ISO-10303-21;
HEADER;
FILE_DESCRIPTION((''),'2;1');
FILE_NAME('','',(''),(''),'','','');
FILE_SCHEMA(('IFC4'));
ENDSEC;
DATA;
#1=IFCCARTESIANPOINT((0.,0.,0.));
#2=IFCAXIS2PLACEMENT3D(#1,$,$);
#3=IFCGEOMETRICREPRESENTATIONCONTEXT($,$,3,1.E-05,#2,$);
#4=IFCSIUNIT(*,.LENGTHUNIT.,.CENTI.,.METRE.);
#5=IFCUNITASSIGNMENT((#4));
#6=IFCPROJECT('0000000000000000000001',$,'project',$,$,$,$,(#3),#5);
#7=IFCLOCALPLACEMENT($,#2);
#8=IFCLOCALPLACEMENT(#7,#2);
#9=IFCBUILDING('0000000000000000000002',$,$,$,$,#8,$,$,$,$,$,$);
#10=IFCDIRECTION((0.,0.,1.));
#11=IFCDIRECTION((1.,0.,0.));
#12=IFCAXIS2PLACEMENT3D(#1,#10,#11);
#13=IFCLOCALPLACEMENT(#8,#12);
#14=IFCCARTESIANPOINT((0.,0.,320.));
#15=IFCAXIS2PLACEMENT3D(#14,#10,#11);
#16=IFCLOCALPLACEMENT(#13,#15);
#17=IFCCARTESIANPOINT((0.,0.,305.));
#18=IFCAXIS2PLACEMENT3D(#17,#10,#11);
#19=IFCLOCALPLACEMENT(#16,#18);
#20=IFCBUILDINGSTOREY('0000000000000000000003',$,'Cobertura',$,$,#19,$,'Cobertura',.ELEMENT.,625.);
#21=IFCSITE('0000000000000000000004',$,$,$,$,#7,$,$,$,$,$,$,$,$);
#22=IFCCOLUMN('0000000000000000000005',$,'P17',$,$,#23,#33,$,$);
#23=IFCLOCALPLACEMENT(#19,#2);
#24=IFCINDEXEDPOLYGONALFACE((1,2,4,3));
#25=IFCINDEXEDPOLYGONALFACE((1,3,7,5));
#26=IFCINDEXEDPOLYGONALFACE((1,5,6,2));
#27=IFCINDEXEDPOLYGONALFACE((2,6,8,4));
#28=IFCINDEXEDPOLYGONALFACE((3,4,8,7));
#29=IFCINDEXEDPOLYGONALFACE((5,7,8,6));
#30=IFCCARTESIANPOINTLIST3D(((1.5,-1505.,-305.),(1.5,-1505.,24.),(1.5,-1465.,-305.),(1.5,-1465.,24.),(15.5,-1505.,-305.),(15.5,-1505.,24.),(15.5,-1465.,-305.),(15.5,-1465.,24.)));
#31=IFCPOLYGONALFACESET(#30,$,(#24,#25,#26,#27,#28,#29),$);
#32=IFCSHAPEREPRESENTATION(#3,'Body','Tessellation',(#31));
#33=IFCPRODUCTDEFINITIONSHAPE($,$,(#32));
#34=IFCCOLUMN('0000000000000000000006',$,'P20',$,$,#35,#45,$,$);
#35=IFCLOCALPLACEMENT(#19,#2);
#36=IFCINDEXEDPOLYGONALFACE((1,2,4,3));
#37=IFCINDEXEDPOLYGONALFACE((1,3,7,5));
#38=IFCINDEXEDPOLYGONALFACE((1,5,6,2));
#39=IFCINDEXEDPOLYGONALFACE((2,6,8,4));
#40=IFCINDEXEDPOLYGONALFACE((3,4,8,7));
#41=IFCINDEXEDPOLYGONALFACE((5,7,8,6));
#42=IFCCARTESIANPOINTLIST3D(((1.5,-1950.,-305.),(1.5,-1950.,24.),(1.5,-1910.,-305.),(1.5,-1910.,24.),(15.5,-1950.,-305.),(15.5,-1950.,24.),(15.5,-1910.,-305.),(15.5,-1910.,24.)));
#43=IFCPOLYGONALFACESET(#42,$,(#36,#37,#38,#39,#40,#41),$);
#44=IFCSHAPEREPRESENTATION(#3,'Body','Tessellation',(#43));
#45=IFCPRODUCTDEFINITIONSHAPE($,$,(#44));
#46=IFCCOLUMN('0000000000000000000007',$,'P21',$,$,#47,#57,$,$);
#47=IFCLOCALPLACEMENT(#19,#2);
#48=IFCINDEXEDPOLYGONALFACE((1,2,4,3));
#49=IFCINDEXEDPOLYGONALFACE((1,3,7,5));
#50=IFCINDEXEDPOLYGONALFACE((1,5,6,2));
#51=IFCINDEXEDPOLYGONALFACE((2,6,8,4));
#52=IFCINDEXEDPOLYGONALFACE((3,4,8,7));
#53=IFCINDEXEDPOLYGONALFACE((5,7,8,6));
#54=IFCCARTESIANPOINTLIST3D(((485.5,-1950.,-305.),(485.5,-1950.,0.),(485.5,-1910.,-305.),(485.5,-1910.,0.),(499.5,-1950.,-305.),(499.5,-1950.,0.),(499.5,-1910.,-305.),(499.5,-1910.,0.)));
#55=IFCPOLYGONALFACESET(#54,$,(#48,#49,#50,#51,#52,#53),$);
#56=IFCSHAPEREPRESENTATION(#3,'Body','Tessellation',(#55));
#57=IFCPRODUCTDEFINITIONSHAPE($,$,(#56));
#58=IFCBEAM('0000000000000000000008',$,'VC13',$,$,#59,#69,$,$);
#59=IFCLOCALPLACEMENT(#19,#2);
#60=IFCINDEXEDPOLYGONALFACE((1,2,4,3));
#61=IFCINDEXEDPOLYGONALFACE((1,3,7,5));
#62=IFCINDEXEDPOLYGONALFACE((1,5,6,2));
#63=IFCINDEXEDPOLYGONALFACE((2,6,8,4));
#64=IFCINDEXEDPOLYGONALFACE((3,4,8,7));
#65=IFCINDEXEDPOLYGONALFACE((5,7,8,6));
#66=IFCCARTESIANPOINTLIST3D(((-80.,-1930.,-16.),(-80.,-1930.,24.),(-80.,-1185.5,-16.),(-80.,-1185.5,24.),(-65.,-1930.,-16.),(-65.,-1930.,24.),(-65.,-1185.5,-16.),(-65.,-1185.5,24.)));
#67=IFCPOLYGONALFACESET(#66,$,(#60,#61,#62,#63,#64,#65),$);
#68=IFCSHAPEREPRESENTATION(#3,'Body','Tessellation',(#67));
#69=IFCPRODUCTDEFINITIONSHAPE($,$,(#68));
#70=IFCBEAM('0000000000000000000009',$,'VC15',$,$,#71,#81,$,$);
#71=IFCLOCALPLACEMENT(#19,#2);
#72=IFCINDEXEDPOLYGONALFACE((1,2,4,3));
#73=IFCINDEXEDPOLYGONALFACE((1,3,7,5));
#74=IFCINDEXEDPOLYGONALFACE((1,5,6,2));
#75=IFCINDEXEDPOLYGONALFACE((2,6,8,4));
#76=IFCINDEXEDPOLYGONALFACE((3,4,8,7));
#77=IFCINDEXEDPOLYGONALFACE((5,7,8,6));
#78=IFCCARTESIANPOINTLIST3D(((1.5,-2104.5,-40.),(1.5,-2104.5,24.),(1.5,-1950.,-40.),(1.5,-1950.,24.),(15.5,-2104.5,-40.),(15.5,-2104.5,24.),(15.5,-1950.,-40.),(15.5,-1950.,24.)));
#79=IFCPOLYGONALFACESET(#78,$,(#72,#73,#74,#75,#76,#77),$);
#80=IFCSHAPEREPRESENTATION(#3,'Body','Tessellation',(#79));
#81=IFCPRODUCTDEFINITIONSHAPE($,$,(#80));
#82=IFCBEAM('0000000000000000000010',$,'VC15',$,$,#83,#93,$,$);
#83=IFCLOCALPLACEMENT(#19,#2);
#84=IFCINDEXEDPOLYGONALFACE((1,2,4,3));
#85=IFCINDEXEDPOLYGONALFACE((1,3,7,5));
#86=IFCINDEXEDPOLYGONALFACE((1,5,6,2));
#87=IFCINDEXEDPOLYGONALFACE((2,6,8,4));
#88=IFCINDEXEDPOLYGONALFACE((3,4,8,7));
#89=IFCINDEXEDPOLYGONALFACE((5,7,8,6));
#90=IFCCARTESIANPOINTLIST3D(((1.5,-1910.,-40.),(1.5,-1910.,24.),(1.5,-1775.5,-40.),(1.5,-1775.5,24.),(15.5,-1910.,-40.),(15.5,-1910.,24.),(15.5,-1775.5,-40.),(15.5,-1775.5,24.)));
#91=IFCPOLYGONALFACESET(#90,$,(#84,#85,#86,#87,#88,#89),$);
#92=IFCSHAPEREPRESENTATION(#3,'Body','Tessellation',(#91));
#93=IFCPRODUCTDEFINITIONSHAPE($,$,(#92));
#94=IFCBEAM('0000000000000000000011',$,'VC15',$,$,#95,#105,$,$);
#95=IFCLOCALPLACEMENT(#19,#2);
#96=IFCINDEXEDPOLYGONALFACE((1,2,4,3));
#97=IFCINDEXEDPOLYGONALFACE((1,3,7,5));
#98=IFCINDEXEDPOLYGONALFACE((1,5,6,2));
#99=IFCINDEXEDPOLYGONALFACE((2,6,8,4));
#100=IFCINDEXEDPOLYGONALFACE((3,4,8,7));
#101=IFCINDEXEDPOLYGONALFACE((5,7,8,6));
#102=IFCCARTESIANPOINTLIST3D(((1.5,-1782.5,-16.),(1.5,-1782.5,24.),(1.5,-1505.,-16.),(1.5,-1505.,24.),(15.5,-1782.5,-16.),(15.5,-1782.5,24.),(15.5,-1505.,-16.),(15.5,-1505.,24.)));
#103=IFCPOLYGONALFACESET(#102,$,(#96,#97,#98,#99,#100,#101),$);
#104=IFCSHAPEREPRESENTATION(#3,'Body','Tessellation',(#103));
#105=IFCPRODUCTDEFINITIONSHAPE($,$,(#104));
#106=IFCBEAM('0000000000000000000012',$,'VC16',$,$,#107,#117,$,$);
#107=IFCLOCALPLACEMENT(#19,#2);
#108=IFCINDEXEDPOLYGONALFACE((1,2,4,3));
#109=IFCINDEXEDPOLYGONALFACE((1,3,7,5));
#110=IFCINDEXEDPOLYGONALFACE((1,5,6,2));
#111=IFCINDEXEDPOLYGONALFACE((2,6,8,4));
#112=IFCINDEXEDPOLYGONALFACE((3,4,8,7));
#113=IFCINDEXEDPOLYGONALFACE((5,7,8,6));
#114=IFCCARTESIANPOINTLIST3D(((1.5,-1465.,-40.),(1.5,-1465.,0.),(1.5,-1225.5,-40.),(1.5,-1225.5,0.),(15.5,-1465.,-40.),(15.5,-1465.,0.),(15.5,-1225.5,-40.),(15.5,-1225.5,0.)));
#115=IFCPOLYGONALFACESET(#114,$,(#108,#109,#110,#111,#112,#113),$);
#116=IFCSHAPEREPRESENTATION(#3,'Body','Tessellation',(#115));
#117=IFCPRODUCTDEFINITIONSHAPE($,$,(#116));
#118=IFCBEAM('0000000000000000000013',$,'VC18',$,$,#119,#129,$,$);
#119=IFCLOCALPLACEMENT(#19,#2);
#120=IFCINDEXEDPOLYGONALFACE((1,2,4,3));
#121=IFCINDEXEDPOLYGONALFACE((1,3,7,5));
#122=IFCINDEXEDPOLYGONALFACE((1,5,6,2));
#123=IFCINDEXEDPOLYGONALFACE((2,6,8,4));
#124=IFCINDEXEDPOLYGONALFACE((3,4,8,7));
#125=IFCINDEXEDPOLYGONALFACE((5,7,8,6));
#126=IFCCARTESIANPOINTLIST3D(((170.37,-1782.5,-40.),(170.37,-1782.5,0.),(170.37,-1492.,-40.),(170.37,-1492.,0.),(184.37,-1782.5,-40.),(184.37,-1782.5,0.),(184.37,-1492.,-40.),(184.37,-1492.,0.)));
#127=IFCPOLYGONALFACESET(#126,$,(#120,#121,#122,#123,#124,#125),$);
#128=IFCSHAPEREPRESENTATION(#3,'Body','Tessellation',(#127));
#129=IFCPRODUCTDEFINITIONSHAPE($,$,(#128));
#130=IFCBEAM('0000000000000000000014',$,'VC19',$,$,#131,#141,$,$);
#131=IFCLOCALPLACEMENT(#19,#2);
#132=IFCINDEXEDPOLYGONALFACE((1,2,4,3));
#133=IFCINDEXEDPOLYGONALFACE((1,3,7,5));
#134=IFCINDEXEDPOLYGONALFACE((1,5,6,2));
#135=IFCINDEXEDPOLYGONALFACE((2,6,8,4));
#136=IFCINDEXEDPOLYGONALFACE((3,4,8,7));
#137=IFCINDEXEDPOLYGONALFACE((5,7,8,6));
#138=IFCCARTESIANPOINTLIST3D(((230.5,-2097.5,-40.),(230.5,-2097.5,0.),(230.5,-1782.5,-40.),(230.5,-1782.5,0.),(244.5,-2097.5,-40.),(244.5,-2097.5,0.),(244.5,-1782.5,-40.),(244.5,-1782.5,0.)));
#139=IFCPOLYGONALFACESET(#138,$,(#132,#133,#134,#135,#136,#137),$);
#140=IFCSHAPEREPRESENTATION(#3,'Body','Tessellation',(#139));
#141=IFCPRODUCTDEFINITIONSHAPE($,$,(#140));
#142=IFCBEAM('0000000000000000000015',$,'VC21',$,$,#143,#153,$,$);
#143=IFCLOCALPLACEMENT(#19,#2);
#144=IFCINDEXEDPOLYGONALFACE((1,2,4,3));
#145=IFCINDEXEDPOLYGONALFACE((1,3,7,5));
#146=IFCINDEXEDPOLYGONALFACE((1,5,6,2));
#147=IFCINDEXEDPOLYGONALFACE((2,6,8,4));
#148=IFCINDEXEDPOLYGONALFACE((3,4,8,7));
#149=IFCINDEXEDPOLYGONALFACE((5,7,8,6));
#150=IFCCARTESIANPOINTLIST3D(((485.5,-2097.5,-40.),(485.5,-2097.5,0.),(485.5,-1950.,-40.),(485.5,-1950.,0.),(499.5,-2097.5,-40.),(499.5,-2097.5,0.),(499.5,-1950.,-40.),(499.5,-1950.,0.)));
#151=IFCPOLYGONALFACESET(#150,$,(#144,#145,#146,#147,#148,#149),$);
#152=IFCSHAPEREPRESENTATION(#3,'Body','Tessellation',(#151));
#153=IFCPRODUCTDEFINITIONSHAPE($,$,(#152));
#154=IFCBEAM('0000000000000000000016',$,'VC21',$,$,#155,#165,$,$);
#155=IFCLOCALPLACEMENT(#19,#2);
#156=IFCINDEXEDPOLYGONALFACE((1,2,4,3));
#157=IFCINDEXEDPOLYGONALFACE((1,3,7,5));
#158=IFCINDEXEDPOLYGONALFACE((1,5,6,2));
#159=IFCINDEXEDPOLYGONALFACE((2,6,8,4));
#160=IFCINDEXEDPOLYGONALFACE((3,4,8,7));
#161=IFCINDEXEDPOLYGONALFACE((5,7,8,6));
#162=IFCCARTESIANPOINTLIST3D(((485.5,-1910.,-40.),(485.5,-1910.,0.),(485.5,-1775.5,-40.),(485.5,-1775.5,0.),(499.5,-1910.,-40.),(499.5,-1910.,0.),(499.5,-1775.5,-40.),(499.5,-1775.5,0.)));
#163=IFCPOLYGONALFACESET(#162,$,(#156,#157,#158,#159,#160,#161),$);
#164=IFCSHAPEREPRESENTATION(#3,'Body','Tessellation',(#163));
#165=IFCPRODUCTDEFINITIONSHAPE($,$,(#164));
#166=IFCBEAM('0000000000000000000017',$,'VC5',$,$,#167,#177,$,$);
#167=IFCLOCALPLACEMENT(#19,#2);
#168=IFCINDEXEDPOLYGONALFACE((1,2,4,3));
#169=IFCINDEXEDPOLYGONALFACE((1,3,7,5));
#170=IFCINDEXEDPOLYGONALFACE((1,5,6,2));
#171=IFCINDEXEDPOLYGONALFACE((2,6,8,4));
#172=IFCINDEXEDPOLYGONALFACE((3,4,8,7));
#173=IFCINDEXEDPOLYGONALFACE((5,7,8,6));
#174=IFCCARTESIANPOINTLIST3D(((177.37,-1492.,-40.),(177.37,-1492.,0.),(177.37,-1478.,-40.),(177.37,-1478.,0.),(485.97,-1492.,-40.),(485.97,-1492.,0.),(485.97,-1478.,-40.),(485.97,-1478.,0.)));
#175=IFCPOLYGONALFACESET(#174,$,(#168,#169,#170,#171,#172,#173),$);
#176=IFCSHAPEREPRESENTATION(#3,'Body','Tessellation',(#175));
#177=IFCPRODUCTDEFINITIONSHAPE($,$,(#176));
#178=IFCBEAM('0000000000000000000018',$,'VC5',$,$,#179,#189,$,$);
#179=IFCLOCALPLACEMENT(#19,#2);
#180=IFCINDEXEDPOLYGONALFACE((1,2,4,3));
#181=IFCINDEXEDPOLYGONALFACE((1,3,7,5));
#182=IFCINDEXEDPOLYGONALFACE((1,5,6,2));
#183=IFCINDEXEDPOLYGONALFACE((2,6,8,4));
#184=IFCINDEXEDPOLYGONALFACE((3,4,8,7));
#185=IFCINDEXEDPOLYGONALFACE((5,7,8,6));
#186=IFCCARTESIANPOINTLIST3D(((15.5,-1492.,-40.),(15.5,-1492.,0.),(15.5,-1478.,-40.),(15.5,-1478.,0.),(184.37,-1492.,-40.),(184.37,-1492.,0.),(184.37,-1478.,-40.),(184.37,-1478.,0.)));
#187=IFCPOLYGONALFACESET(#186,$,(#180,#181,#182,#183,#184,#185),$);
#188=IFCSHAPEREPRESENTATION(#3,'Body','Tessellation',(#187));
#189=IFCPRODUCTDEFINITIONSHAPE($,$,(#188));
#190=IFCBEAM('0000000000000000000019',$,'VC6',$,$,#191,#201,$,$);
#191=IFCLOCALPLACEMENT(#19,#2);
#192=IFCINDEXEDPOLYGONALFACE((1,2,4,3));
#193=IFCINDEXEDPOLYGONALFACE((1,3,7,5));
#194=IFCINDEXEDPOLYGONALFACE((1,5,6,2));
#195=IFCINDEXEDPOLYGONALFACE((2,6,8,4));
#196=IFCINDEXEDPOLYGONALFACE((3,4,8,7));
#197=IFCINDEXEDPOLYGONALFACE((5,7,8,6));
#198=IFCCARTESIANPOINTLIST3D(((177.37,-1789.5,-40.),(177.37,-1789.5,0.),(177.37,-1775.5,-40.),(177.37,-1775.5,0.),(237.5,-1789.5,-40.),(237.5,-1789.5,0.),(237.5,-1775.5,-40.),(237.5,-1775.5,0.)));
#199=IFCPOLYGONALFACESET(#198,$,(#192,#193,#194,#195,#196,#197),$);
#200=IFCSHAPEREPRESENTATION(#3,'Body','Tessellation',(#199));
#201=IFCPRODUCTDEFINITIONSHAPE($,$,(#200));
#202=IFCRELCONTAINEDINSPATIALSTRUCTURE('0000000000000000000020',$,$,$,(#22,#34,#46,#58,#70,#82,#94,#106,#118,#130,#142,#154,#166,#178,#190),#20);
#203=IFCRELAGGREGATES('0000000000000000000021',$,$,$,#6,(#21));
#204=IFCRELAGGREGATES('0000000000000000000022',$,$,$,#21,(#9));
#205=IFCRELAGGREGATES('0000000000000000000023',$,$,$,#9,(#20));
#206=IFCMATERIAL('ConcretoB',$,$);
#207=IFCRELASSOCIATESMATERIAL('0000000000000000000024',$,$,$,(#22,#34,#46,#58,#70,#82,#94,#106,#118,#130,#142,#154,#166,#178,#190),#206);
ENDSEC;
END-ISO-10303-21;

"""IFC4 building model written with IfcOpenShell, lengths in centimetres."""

from ifc_helpers import new_model, si_unit, frame, origin, origin_with_axes, place, context, project, spatial, polyline, outline, extrude, material, element, save


model = new_model("IFC4")

# Units and contexts
context_of_model = context(None, 3, precision=1e-05, world=origin())
ifc_project = project(units=[si_unit("LENGTHUNIT", "METRE", prefix="CENTI")], contexts=[context_of_model])

# Site, building, storey
site_placement = place(None, origin())
site = spatial("IfcSite", under=ifc_project, at=site_placement)
building_placement = place(site_placement, origin())
building = spatial("IfcBuilding", under=site, at=building_placement)
placement_1 = place(building_placement, origin_with_axes())
placement_2 = place(placement_1, frame((0.0, 0.0, 320.0), z_axis=(0.0, 0.0, 1.0), x_axis=(1.0, 0.0, 0.0)))
storey_placement = place(placement_2, frame((0.0, 0.0, 305.0), z_axis=(0.0, 0.0, 1.0), x_axis=(1.0, 0.0, 0.0)))
storey = spatial("IfcBuildingStorey", under=building, at=storey_placement, Name="Cobertura", LongName="Cobertura", CompositionType="ELEMENT", Elevation=625.0)

# Columns
ifc_material = material(Name="ConcretoB")
for number, where, z_axis, x_axis, name in (
    (1, (8.5, -1485.0, 24.0), (0.0, 0.0, 1.0), (1.0, 0.0, 0.0), "P17"),
    (2, (8.5, -1930.0, 24.0), (0.0, 0.0, 1.0), (1.0, 0.0, 0.0), "P20"),
):
    element("IfcColumn", number, at=place(storey_placement, frame(where, z_axis=z_axis, x_axis=x_axis)), inside=storey, material=ifc_material, Name=name, context=context_of_model, shape_type="SolidModel", body=[
        extrude(outline(polyline([(-7.0, -20.0), (7.0, -20.0), (7.0, 20.0), (-7.0, 20.0), (-7.0, -20.0)])), frame((0.0, 0.0, 0.0), z_axis=(0.0, 0.0, 1.0), x_axis=(1.0, 0.0, 0.0)), (0.0, 0.0, -1.0), 329.0),
    ])
column_placement = place(storey_placement, frame((492.5, -1930.0, 0.0), z_axis=(0.0, 0.0, 1.0), x_axis=(1.0, 0.0, 0.0)))
element("IfcColumn", 3, at=column_placement, inside=storey, material=ifc_material, Name="P21", context=context_of_model, shape_type="SolidModel", body=[
    extrude(outline(polyline([(-7.0, -20.0), (7.0, -20.0), (7.0, 20.0), (-7.0, 20.0), (-7.0, -20.0)])), origin_with_axes(), (0.0, 0.0, -1.0), 305.0),
])

# Beams
beam_1_placement = place(storey_placement, frame((-72.5, -1557.75, 24.0), z_axis=(0.0, 0.0, 1.0), x_axis=(1.0, 0.0, 0.0)))
element("IfcBeam", 4, at=beam_1_placement, inside=storey, material=ifc_material, Name="VC13", context=context_of_model, shape_type="SolidModel", body=[
    extrude(outline(polyline([(-7.5, -20.0), (7.5, -20.0), (7.5, 20.0), (-7.5, 20.0), (-7.5, -20.0)])), frame((0.0, -372.25, -20.0), z_axis=(0.0, 1.0, 0.0), x_axis=(1.0, 0.0, 0.0)), (0.0, 0.0, 1.0), 744.5),
])
beam_2_placement = place(storey_placement, frame((8.5, -2027.25, 24.0), z_axis=(0.0, 0.0, 1.0), x_axis=(1.0, 0.0, 0.0)))
element("IfcBeam", 5, at=beam_2_placement, inside=storey, material=ifc_material, Name="VC15", context=context_of_model, shape_type="SolidModel", body=[
    extrude(outline(polyline([(-7.0, -32.0), (7.0, -32.0), (7.0, 32.0), (-7.0, 32.0), (-7.0, -32.0)])), frame((0.0, -77.25, -32.0), z_axis=(0.0, 1.0, 0.0), x_axis=(1.0, 0.0, 0.0)), (0.0, 0.0, 1.0), 154.5),
])
beam_3_placement = place(storey_placement, frame((8.5, -1842.75, 24.0), z_axis=(0.0, 0.0, 1.0), x_axis=(1.0, 0.0, 0.0)))
element("IfcBeam", 6, at=beam_3_placement, inside=storey, material=ifc_material, Name="VC15", context=context_of_model, shape_type="SolidModel", body=[
    extrude(outline(polyline([(-7.0, -32.0), (7.0, -32.0), (7.0, 32.0), (-7.0, 32.0), (-7.0, -32.0)])), frame((0.0, -67.25, -32.0), z_axis=(0.0, 1.0, 0.0), x_axis=(1.0, 0.0, 0.0)), (0.0, 0.0, 1.0), 134.5),
])
beam_4_placement = place(storey_placement, frame((8.5, -1643.75, 24.0), z_axis=(0.0, 0.0, 1.0), x_axis=(1.0, 0.0, 0.0)))
element("IfcBeam", 7, at=beam_4_placement, inside=storey, material=ifc_material, Name="VC15", context=context_of_model, shape_type="SolidModel", body=[
    extrude(outline(polyline([(-7.0, -20.0), (7.0, -20.0), (7.0, 20.0), (-7.0, 20.0), (-7.0, -20.0)])), frame((0.0, -138.75, -20.0), z_axis=(0.0, 1.0, 0.0), x_axis=(1.0, 0.0, 0.0)), (0.0, 0.0, 1.0), 277.5),
])
beam_5_placement = place(storey_placement, frame((8.5, -1345.25, 0.0), z_axis=(0.0, 0.0, 1.0), x_axis=(1.0, 0.0, 0.0)))
element("IfcBeam", 8, at=beam_5_placement, inside=storey, material=ifc_material, Name="VC16", context=context_of_model, shape_type="SolidModel", body=[
    extrude(outline(polyline([(-7.0, -20.0), (7.0, -20.0), (7.0, 20.0), (-7.0, 20.0), (-7.0, -20.0)])), frame((0.0, -119.75, -20.0), z_axis=(0.0, 1.0, 0.0), x_axis=(1.0, 0.0, 0.0)), (0.0, 0.0, 1.0), 239.5),
])
beam_6_placement = place(storey_placement, frame((177.37, -1637.25, 0.0), z_axis=(0.0, 0.0, 1.0), x_axis=(1.0, 0.0, 0.0)))
element("IfcBeam", 9, at=beam_6_placement, inside=storey, material=ifc_material, Name="VC18", context=context_of_model, shape_type="SolidModel", body=[
    extrude(outline(polyline([(-7.0, -20.0), (7.0, -20.0), (7.0, 20.0), (-7.0, 20.0), (-7.0, -20.0)])), frame((0.0, -145.25, -20.0), z_axis=(0.0, 1.0, 0.0), x_axis=(1.0, 0.0, 0.0)), (0.0, 0.0, 1.0), 290.5),
])
beam_7_placement = place(storey_placement, frame((237.5, -1940.0, 0.0), z_axis=(0.0, 0.0, 1.0), x_axis=(1.0, 0.0, 0.0)))
element("IfcBeam", 10, at=beam_7_placement, inside=storey, material=ifc_material, Name="VC19", context=context_of_model, shape_type="SolidModel", body=[
    extrude(outline(polyline([(-7.0, -20.0), (7.0, -20.0), (7.0, 20.0), (-7.0, 20.0), (-7.0, -20.0)])), frame((0.0, -157.5, -20.0), z_axis=(0.0, 1.0, 0.0), x_axis=(1.0, 0.0, 0.0)), (0.0, 0.0, 1.0), 315.0),
])
beam_8_placement = place(storey_placement, frame((492.5, -2023.75, 0.0), z_axis=(0.0, 0.0, 1.0), x_axis=(1.0, 0.0, 0.0)))
element("IfcBeam", 11, at=beam_8_placement, inside=storey, material=ifc_material, Name="VC21", context=context_of_model, shape_type="SolidModel", body=[
    extrude(outline(polyline([(-7.0, -20.0), (7.0, -20.0), (7.0, 20.0), (-7.0, 20.0), (-7.0, -20.0)])), frame((0.0, -73.75, -20.0), z_axis=(0.0, 1.0, 0.0), x_axis=(1.0, 0.0, 0.0)), (0.0, 0.0, 1.0), 147.5),
])
beam_9_placement = place(storey_placement, frame((492.5, -1842.75, 0.0), z_axis=(0.0, 0.0, 1.0), x_axis=(1.0, 0.0, 0.0)))
element("IfcBeam", 12, at=beam_9_placement, inside=storey, material=ifc_material, Name="VC21", context=context_of_model, shape_type="SolidModel", body=[
    extrude(outline(polyline([(-7.0, -20.0), (7.0, -20.0), (7.0, 20.0), (-7.0, 20.0), (-7.0, -20.0)])), frame((0.0, -67.25, -20.0), z_axis=(0.0, 1.0, 0.0), x_axis=(1.0, 0.0, 0.0)), (0.0, 0.0, 1.0), 134.5),
])
beam_10_placement = place(storey_placement, frame((331.67, -1485.0, 0.0), z_axis=(0.0, 0.0, 1.0), x_axis=(1.0, 0.0, 0.0)))
element("IfcBeam", 13, at=beam_10_placement, inside=storey, material=ifc_material, Name="VC5", context=context_of_model, shape_type="SolidModel", body=[
    extrude(outline(polyline([(-7.0, -20.0), (7.0, -20.0), (7.0, 20.0), (-7.0, 20.0), (-7.0, -20.0)])), frame((-154.3, 0.0, -20.0), z_axis=(1.0, 0.0, 0.0), x_axis=(0.0, -1.0, 0.0)), (0.0, 0.0, 1.0), 308.6),
])
beam_11_placement = place(storey_placement, frame((99.94, -1485.0, 0.0), z_axis=(0.0, 0.0, 1.0), x_axis=(1.0, 0.0, 0.0)))
element("IfcBeam", 14, at=beam_11_placement, inside=storey, material=ifc_material, Name="VC5", context=context_of_model, shape_type="SolidModel", body=[
    extrude(outline(polyline([(-7.0, -20.0), (7.0, -20.0), (7.0, 20.0), (-7.0, 20.0), (-7.0, -20.0)])), frame((-84.44, 0.0, -20.0), z_axis=(1.0, 0.0, 0.0), x_axis=(0.0, -1.0, 0.0)), (0.0, 0.0, 1.0), 168.87),
])
beam_12_placement = place(storey_placement, frame((207.44, -1782.5, 0.0), z_axis=(0.0, 0.0, 1.0), x_axis=(1.0, 0.0, 0.0)))
element("IfcBeam", 15, at=beam_12_placement, inside=storey, material=ifc_material, Name="VC6", context=context_of_model, shape_type="SolidModel", body=[
    extrude(outline(polyline([(-7.0, -20.0), (7.0, -20.0), (7.0, 20.0), (-7.0, 20.0), (-7.0, -20.0)])), frame((-30.07, 0.0, -20.0), z_axis=(1.0, 0.0, 0.0), x_axis=(0.0, -1.0, 0.0)), (0.0, 0.0, 1.0), 60.13),
])

save(model, "model.ifc")
